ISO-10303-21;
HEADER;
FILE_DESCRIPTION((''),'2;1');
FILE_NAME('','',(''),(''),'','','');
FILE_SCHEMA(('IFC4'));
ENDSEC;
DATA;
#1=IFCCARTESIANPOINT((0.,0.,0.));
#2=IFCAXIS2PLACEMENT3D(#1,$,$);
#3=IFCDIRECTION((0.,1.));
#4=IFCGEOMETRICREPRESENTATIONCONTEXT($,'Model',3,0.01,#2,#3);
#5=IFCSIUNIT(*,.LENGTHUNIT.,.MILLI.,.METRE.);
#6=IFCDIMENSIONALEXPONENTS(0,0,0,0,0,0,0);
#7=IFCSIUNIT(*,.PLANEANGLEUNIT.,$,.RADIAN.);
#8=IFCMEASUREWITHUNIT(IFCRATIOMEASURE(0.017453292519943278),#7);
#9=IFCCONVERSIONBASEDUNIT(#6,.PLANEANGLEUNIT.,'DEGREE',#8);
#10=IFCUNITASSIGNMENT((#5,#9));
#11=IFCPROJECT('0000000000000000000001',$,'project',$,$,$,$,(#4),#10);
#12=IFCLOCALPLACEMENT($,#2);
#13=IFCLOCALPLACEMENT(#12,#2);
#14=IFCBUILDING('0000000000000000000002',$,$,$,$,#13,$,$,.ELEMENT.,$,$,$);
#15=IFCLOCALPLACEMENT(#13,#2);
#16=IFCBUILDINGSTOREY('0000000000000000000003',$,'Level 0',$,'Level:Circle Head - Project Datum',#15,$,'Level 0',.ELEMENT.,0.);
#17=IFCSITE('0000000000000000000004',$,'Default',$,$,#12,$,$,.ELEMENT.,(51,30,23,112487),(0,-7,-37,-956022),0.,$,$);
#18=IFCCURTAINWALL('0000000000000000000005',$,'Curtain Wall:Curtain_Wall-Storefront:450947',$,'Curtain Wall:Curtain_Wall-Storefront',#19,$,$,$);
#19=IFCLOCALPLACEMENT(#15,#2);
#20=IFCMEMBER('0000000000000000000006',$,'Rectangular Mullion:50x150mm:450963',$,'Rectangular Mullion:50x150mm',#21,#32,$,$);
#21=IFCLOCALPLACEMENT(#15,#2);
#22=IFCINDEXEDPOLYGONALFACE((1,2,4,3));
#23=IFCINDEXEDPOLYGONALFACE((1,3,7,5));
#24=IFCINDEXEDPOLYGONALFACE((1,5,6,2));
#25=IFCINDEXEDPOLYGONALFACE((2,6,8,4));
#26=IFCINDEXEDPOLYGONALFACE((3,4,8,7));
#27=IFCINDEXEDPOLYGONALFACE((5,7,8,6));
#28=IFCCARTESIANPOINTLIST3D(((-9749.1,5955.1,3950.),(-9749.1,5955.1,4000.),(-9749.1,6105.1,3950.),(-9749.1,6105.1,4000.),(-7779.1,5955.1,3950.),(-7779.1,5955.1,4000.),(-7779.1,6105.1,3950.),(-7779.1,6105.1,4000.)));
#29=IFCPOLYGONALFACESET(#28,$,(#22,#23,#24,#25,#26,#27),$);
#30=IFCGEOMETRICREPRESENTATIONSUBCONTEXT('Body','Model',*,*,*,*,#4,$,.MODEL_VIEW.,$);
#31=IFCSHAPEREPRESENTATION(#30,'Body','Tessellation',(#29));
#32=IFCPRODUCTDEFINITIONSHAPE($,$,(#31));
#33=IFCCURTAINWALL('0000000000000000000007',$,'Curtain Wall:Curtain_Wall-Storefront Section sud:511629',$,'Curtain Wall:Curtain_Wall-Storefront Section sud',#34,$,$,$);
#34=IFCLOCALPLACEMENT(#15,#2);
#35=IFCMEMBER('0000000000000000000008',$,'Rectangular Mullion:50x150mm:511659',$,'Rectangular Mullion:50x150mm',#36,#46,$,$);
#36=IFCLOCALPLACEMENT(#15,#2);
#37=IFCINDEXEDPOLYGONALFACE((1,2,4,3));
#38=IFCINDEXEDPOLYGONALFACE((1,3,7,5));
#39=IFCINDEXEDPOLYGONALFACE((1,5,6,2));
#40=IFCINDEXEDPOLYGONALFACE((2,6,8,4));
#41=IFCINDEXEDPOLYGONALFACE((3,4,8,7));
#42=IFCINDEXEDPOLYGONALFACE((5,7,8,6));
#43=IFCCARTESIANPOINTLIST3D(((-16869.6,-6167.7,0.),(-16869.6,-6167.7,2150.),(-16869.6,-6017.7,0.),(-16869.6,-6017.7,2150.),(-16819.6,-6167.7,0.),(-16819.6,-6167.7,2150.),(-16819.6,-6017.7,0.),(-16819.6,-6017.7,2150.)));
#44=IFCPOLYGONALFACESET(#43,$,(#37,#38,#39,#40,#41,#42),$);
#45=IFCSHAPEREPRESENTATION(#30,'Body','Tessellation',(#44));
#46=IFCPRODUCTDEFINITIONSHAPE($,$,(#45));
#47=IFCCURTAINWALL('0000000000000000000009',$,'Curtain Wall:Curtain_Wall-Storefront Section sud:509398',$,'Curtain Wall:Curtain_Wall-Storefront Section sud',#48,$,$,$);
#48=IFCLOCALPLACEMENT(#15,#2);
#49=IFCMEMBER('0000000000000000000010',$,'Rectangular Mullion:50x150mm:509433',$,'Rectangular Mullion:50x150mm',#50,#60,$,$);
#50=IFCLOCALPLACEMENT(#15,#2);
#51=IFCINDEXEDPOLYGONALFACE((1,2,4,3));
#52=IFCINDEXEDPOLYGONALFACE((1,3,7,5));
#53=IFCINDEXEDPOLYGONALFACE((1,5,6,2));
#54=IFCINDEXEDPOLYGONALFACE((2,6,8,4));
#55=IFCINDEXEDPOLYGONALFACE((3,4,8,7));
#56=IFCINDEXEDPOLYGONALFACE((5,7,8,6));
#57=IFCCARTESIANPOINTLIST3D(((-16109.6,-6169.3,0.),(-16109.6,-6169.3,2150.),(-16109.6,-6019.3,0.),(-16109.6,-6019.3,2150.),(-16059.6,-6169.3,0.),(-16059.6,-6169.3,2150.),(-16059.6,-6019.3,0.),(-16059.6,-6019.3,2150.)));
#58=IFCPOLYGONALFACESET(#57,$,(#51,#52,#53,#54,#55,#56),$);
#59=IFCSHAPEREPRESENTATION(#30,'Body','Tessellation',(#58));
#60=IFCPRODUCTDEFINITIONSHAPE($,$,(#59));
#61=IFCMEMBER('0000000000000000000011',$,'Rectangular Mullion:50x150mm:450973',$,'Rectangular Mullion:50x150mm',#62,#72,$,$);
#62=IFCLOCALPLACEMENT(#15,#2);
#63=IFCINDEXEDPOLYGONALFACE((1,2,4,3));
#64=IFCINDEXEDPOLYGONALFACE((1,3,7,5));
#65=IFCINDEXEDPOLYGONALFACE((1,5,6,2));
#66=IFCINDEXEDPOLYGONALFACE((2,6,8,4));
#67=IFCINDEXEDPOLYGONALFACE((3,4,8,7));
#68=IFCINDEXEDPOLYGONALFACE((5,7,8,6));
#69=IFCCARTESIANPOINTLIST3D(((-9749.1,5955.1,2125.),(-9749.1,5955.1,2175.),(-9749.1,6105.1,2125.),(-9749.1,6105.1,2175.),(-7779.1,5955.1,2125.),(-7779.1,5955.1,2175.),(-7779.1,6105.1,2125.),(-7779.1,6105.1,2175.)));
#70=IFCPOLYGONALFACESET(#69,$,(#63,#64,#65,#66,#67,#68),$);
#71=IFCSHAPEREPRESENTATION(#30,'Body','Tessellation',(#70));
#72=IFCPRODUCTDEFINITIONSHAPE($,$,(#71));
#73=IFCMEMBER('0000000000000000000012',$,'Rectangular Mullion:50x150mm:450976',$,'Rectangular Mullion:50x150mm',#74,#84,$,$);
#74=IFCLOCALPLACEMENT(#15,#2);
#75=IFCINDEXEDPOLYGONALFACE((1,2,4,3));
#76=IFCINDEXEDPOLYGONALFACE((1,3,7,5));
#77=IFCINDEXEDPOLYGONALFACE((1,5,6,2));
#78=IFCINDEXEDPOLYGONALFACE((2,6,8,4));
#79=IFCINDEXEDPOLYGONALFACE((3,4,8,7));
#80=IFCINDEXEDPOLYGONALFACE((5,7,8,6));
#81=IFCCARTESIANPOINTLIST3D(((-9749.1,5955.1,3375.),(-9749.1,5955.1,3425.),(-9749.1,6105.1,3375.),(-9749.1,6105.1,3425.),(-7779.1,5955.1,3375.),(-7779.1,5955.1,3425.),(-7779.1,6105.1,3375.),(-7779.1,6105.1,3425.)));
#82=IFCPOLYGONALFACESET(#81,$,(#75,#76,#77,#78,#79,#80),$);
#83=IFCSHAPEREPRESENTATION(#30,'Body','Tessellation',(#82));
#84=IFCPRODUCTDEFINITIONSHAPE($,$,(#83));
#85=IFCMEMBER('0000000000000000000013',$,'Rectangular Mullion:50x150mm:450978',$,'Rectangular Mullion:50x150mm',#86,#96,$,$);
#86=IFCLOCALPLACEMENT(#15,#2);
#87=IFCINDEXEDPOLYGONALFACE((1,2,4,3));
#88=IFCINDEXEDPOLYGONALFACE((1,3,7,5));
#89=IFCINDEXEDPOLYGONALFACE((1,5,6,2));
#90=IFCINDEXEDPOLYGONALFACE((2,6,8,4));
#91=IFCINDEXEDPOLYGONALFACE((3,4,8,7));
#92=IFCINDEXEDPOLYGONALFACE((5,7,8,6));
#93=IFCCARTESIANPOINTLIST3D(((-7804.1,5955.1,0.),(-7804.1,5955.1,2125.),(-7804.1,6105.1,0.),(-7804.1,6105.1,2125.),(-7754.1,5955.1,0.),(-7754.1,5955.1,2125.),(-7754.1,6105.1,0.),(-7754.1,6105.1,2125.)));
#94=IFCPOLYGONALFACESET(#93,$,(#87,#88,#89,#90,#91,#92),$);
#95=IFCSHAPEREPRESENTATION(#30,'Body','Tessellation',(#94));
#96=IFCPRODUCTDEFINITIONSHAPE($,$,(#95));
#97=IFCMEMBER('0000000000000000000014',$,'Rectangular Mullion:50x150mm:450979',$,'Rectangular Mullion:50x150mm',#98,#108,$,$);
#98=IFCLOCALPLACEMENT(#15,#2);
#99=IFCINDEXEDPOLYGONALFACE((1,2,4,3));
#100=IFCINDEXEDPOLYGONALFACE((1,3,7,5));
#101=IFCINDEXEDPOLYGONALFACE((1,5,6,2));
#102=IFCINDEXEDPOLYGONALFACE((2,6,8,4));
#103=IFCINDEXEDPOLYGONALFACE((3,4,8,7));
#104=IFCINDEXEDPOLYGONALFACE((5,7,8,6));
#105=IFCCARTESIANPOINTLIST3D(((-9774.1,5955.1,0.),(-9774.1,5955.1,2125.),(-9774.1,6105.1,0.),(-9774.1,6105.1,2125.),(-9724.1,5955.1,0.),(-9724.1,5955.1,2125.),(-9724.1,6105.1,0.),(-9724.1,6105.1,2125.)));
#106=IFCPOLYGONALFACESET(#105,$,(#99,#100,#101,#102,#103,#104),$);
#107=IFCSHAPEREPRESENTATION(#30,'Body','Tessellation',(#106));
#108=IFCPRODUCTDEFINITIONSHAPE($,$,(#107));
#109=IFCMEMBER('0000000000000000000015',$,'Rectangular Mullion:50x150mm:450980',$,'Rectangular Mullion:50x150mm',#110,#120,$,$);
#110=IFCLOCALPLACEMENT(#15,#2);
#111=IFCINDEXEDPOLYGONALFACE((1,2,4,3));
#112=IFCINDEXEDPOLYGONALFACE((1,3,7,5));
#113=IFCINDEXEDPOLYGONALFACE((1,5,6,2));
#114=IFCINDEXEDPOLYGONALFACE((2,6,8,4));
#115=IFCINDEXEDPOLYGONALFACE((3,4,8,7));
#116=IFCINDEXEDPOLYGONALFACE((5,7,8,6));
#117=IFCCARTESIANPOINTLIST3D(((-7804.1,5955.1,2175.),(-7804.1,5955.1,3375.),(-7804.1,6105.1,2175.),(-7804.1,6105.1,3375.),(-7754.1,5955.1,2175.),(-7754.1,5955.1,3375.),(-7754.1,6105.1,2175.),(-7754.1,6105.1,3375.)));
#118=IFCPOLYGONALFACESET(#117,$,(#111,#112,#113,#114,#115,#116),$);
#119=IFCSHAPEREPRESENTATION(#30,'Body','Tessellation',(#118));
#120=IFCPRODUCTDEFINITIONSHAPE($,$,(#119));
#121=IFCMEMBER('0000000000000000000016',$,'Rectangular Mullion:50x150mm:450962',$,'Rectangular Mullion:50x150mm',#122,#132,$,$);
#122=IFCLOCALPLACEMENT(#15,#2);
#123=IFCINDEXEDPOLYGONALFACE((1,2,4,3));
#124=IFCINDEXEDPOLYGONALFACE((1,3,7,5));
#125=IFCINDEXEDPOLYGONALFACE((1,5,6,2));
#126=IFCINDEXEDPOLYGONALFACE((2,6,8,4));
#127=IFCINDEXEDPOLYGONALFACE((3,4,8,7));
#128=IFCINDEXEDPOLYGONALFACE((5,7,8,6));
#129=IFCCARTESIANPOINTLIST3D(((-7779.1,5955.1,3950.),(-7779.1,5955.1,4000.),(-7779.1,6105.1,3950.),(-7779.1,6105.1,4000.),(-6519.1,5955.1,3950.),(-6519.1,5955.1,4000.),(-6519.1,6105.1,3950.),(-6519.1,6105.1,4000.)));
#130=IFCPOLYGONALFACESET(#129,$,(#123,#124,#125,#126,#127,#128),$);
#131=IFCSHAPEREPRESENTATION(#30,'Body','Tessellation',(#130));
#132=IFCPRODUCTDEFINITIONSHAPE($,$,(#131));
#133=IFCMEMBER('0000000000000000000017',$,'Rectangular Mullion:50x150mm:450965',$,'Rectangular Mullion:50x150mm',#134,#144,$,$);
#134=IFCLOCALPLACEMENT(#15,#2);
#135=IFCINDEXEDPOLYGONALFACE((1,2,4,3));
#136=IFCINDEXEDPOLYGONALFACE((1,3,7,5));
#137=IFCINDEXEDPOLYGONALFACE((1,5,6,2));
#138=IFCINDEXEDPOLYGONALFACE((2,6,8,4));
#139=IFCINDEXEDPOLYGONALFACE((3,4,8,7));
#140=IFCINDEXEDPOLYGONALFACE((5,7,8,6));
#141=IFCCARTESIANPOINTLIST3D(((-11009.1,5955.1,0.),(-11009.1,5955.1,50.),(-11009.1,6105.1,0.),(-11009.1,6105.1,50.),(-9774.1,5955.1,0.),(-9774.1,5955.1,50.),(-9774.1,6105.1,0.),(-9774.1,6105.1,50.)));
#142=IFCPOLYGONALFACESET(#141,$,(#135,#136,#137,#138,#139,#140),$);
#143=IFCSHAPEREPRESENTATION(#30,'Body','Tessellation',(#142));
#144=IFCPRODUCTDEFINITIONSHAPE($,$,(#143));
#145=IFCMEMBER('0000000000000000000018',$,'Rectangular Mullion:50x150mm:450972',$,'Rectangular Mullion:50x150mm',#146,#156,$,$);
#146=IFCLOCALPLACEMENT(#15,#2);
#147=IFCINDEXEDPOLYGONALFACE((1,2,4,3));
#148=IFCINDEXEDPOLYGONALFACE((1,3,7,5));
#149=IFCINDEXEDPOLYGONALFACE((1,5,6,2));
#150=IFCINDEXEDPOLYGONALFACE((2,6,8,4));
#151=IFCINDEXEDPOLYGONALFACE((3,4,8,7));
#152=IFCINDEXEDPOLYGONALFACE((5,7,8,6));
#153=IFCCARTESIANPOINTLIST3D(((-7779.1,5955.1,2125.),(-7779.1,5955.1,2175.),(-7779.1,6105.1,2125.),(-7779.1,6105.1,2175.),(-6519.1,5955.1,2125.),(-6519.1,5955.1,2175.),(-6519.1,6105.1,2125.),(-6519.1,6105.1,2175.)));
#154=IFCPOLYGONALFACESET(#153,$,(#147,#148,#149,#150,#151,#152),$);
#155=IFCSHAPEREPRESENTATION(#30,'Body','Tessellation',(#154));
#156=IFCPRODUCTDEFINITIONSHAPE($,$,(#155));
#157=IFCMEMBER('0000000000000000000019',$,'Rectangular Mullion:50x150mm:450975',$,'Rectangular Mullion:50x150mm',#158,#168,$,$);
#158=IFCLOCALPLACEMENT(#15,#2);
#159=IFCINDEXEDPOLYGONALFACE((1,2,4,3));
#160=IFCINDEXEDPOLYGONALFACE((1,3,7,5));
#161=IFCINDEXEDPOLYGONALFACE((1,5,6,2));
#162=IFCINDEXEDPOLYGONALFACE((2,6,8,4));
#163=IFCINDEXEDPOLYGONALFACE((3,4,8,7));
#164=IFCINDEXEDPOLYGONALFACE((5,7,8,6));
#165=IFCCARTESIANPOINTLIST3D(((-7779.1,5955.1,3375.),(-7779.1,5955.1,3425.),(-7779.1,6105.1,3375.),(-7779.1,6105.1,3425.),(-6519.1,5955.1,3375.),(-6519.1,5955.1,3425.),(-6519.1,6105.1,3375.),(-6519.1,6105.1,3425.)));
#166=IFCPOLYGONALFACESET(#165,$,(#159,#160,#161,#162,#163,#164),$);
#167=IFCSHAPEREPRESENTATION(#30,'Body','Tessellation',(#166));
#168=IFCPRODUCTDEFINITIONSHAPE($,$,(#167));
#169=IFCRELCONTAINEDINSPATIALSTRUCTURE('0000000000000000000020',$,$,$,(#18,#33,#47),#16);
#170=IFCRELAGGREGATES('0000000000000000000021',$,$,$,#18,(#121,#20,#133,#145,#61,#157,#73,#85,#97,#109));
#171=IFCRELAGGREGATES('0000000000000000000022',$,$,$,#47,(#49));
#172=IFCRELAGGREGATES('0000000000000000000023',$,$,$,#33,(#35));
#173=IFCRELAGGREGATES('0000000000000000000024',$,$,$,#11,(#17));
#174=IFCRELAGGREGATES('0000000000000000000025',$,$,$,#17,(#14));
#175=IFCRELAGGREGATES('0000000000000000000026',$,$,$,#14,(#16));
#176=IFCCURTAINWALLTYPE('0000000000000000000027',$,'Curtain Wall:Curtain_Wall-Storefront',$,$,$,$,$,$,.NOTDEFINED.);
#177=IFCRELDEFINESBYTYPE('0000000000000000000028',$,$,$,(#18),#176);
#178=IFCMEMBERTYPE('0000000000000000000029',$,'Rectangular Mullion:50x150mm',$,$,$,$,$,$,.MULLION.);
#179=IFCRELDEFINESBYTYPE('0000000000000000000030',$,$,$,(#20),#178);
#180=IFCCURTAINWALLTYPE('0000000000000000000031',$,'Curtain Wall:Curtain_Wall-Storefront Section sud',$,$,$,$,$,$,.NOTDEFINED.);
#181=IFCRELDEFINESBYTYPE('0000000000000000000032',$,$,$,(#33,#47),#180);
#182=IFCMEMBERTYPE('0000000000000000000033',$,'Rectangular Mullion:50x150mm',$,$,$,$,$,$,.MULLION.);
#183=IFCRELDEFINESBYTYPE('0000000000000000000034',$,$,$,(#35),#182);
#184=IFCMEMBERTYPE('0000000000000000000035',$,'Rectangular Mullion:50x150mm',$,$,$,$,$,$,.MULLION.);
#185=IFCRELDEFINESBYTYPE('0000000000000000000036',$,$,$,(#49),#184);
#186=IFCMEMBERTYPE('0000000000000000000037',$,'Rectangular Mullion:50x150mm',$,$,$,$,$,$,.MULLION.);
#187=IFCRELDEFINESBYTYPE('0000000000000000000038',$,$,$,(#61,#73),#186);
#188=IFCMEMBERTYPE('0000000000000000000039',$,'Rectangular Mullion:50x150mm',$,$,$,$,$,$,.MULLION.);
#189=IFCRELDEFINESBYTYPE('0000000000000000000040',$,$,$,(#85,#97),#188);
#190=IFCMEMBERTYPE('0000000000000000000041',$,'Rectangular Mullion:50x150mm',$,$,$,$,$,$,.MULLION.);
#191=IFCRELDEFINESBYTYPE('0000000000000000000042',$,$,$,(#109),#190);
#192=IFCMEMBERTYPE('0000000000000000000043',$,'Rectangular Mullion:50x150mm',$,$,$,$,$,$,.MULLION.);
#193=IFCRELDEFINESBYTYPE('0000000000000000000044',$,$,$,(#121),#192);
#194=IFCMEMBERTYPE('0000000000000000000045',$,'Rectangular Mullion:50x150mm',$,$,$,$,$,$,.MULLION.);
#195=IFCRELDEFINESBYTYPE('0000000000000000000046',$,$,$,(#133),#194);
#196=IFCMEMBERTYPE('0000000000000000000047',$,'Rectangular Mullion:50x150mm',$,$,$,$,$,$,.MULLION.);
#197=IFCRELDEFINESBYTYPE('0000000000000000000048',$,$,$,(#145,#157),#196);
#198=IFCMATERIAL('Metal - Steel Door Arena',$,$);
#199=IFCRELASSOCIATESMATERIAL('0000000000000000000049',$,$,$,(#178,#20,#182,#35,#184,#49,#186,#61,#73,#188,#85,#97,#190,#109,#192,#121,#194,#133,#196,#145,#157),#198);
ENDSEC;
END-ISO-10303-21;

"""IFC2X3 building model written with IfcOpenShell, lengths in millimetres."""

from ifc_helpers import new_model, entity, si_unit, converted_unit, direction, frame, origin, origin_2d_with_axis, place, context, subcontext, project, spatial, rectangle, extrude, source, transform, mapped, material, type_object, type_shapes, element, aggregate, save


model = new_model("IFC2X3")

# Units and contexts
model_context = context("Model", 3, precision=0.01, world=origin(), true_north=direction((0.0, 1.0)))
body_context = subcontext(model_context, "Body", "Model", "MODEL_VIEW")
ifc_project = project(units=[si_unit("LENGTHUNIT", "METRE", prefix="MILLI"), converted_unit("PLANEANGLEUNIT", "DEGREE", entity("IfcRatioMeasure", 0.017453292519943278), si_unit("PLANEANGLEUNIT", "RADIAN"), dimensions=[0, 0, 0, 0, 0, 0, 0])], contexts=[model_context])

# Site, building, storey
site_placement = place(None, origin())
site = spatial("IfcSite", under=ifc_project, at=site_placement, Name="Default", CompositionType="ELEMENT", RefLatitude=(51, 30, 23, 112487), RefLongitude=(0, -7, -37, -956022), RefElevation=0.0)
building_placement = place(site_placement, origin())
building = spatial("IfcBuilding", under=site, at=building_placement, CompositionType="ELEMENT")
storey_placement = place(building_placement, origin())
storey = spatial("IfcBuildingStorey", under=building, at=storey_placement, Name="Level 0", ObjectType="Level:Circle Head - Project Datum", LongName="Level 0", CompositionType="ELEMENT", Elevation=0.0)

# Curtain walls, members
curtain_wall_type_1 = type_object("IfcCurtainWallType", Name="Curtain Wall:Curtain_Wall-Storefront", PredefinedType="NOTDEFINED")
curtain_wall_1_placement = place(storey_placement, origin())
curtain_wall_1 = element("IfcCurtainWall", 1, at=curtain_wall_1_placement, inside=storey, type_object=curtain_wall_type_1, Name="Curtain Wall:Curtain_Wall-Storefront:450947", ObjectType="Curtain Wall:Curtain_Wall-Storefront")
ifc_material_1 = material(Name="Metal - Steel Door Arena")
member_type_1 = type_object("IfcMemberType", Name="Rectangular Mullion:50x150mm", PredefinedType="MULLION", material=ifc_material_1)
shared_shape_1 = source(origin(), body_context, "Body", "SweptSolid", [
    extrude(rectangle(XDim=150.0, YDim=50.0, at=origin_2d_with_axis()), frame((-25.0, 0.0, -1970.0), z_axis=(0.0, 0.0, 1.0), x_axis=(0.0, -1.0, 0.0)), (0.0, 0.0, 1.0), 1970.0),
])
type_shapes(member_type_1, [shared_shape_1])
member_1_placement = place(curtain_wall_1_placement, frame((-9749.1, 6030.1, 4000.0), z_axis=(-1.0, 0.0, 0.0), x_axis=(0.0, 0.0, 1.0)))
member_1 = element("IfcMember", 2, at=member_1_placement, type_object=member_type_1, material=ifc_material_1, Name="Rectangular Mullion:50x150mm:450963", ObjectType="Rectangular Mullion:50x150mm", context=body_context, shape_type="MappedRepresentation", body=[
    mapped(shared_shape_1, transform((0.0, 0.0, 0.0), scale=1.0)),
])
curtain_wall_type_2 = type_object("IfcCurtainWallType", Name="Curtain Wall:Curtain_Wall-Storefront Section sud", PredefinedType="NOTDEFINED")
curtain_wall_2_placement = place(storey_placement, origin())
curtain_wall_2 = element("IfcCurtainWall", 3, at=curtain_wall_2_placement, inside=storey, type_object=curtain_wall_type_2, Name="Curtain Wall:Curtain_Wall-Storefront Section sud:511629", ObjectType="Curtain Wall:Curtain_Wall-Storefront Section sud")
member_type_2 = type_object("IfcMemberType", Name="Rectangular Mullion:50x150mm", PredefinedType="MULLION", material=ifc_material_1)
shared_shape_2 = source(origin(), body_context, "Body", "SweptSolid", [
    extrude(rectangle(XDim=150.0, YDim=50.0, at=origin_2d_with_axis()), frame((-25.0, 0.0, -2150.0), z_axis=(0.0, 0.0, 1.0), x_axis=(0.0, -1.0, 0.0)), (0.0, 0.0, 1.0), 2150.0),
])
type_shapes(member_type_2, [shared_shape_2])
member_2_placement = place(curtain_wall_2_placement, frame((-16819.6, -6092.7, 0.0), z_axis=(0.0, 0.0, -1.0), x_axis=(1.0, 0.0, 0.0)))
member_2 = element("IfcMember", 4, at=member_2_placement, type_object=member_type_2, material=ifc_material_1, Name="Rectangular Mullion:50x150mm:511659", ObjectType="Rectangular Mullion:50x150mm", context=body_context, shape_type="MappedRepresentation", body=[
    mapped(shared_shape_2, transform((0.0, 0.0, 0.0), scale=1.0)),
])
curtain_wall_3_placement = place(storey_placement, origin())
curtain_wall_3 = element("IfcCurtainWall", 5, at=curtain_wall_3_placement, inside=storey, type_object=curtain_wall_type_2, Name="Curtain Wall:Curtain_Wall-Storefront Section sud:509398", ObjectType="Curtain Wall:Curtain_Wall-Storefront Section sud")
member_type_3 = type_object("IfcMemberType", Name="Rectangular Mullion:50x150mm", PredefinedType="MULLION", material=ifc_material_1)
shared_shape_3 = source(origin(), body_context, "Body", "SweptSolid", [
    extrude(rectangle(XDim=150.0, YDim=50.0, at=origin_2d_with_axis()), frame((-25.0, 0.0, -2150.0), z_axis=(0.0, 0.0, 1.0), x_axis=(0.0, -1.0, 0.0)), (0.0, 0.0, 1.0), 2150.0),
])
type_shapes(member_type_3, [shared_shape_3])
member_3_placement = place(curtain_wall_3_placement, frame((-16109.6, -6094.3, 2150.0), z_axis=(0.0, 0.0, 1.0), x_axis=(-1.0, 0.0, 0.0)))
member_3 = element("IfcMember", 6, at=member_3_placement, type_object=member_type_3, material=ifc_material_1, Name="Rectangular Mullion:50x150mm:509433", ObjectType="Rectangular Mullion:50x150mm", context=body_context, shape_type="MappedRepresentation", body=[
    mapped(shared_shape_3, transform((0.0, 0.0, 0.0), scale=1.0)),
])

# Members
member_type_4 = type_object("IfcMemberType", Name="Rectangular Mullion:50x150mm", PredefinedType="MULLION", material=ifc_material_1)
shared_shape_4 = source(origin(), body_context, "Body", "SweptSolid", [
    extrude(rectangle(XDim=150.0, YDim=50.0, at=origin_2d_with_axis()), frame((0.0, 0.0, -1970.0), z_axis=(0.0, 0.0, 1.0), x_axis=(0.0, -1.0, 0.0)), (0.0, 0.0, 1.0), 1970.0),
])
type_shapes(member_type_4, [shared_shape_4])
member_4_placement = place(curtain_wall_1_placement, frame((-9749.1, 6030.1, 2150.0), z_axis=(-1.0, 0.0, 0.0), x_axis=(0.0, 0.0, 1.0)))
member_4 = element("IfcMember", 7, at=member_4_placement, type_object=member_type_4, material=ifc_material_1, Name="Rectangular Mullion:50x150mm:450973", ObjectType="Rectangular Mullion:50x150mm", context=body_context, shape_type="MappedRepresentation", body=[
    mapped(shared_shape_4, transform((0.0, 0.0, 0.0), scale=1.0)),
])
member_5_placement = place(curtain_wall_1_placement, frame((-9749.1, 6030.1, 3400.0), z_axis=(-1.0, 0.0, 0.0), x_axis=(0.0, 0.0, 1.0)))
member_5 = element("IfcMember", 8, at=member_5_placement, type_object=member_type_4, material=ifc_material_1, Name="Rectangular Mullion:50x150mm:450976", ObjectType="Rectangular Mullion:50x150mm", context=body_context, shape_type="MappedRepresentation", body=[
    mapped(shared_shape_4, transform((0.0, 0.0, 0.0), scale=1.0)),
])
member_type_5 = type_object("IfcMemberType", Name="Rectangular Mullion:50x150mm", PredefinedType="MULLION", material=ifc_material_1)
shared_shape_5 = source(origin(), body_context, "Body", "SweptSolid", [
    extrude(rectangle(XDim=150.0, YDim=50.0, at=origin_2d_with_axis()), frame((0.0, 0.0, -2125.0), z_axis=(0.0, 0.0, 1.0), x_axis=(0.0, -1.0, 0.0)), (0.0, 0.0, 1.0), 2125.0),
])
type_shapes(member_type_5, [shared_shape_5])
member_6_placement = place(curtain_wall_1_placement, frame((-7779.1, 6030.1, 0.0), z_axis=(0.0, 0.0, -1.0), x_axis=(-1.0, 0.0, 0.0)))
member_6 = element("IfcMember", 9, at=member_6_placement, type_object=member_type_5, material=ifc_material_1, Name="Rectangular Mullion:50x150mm:450978", ObjectType="Rectangular Mullion:50x150mm", context=body_context, shape_type="MappedRepresentation", body=[
    mapped(shared_shape_5, transform((0.0, 0.0, 0.0), scale=1.0)),
])
member_7_placement = place(curtain_wall_1_placement, frame((-9749.1, 6030.1, 0.0), z_axis=(0.0, 0.0, -1.0), x_axis=(-1.0, 0.0, 0.0)))
member_7 = element("IfcMember", 10, at=member_7_placement, type_object=member_type_5, material=ifc_material_1, Name="Rectangular Mullion:50x150mm:450979", ObjectType="Rectangular Mullion:50x150mm", context=body_context, shape_type="MappedRepresentation", body=[
    mapped(shared_shape_5, transform((0.0, 0.0, 0.0), scale=1.0)),
])
member_type_6 = type_object("IfcMemberType", Name="Rectangular Mullion:50x150mm", PredefinedType="MULLION", material=ifc_material_1)
shared_shape_6 = source(origin(), body_context, "Body", "SweptSolid", [
    extrude(rectangle(XDim=150.0, YDim=50.0, at=origin_2d_with_axis()), frame((0.0, 0.0, -1200.0), z_axis=(0.0, 0.0, 1.0), x_axis=(0.0, -1.0, 0.0)), (0.0, 0.0, 1.0), 1200.0),
])
type_shapes(member_type_6, [shared_shape_6])
member_8_placement = place(curtain_wall_1_placement, frame((-7779.1, 6030.1, 2175.0), z_axis=(0.0, 0.0, -1.0), x_axis=(-1.0, 0.0, 0.0)))
member_8 = element("IfcMember", 11, at=member_8_placement, type_object=member_type_6, material=ifc_material_1, Name="Rectangular Mullion:50x150mm:450980", ObjectType="Rectangular Mullion:50x150mm", context=body_context, shape_type="MappedRepresentation", body=[
    mapped(shared_shape_6, transform((0.0, 0.0, 0.0), scale=1.0)),
])
member_type_7 = type_object("IfcMemberType", Name="Rectangular Mullion:50x150mm", PredefinedType="MULLION", material=ifc_material_1)
shared_shape_7 = source(origin(), body_context, "Body", "SweptSolid", [
    extrude(rectangle(XDim=150.0, YDim=50.0, at=origin_2d_with_axis()), frame((-25.0, 0.0, -1260.0), z_axis=(0.0, 0.0, 1.0), x_axis=(0.0, -1.0, 0.0)), (0.0, 0.0, 1.0), 1260.0),
])
type_shapes(member_type_7, [shared_shape_7])
member_9_placement = place(curtain_wall_1_placement, frame((-7779.1, 6030.1, 4000.0), z_axis=(-1.0, 0.0, 0.0), x_axis=(0.0, 0.0, 1.0)))
member_9 = element("IfcMember", 12, at=member_9_placement, type_object=member_type_7, material=ifc_material_1, Name="Rectangular Mullion:50x150mm:450962", ObjectType="Rectangular Mullion:50x150mm", context=body_context, shape_type="MappedRepresentation", body=[
    mapped(shared_shape_7, transform((0.0, 0.0, 0.0), scale=1.0)),
])
member_type_8 = type_object("IfcMemberType", Name="Rectangular Mullion:50x150mm", PredefinedType="MULLION", material=ifc_material_1)
shared_shape_8 = source(origin(), body_context, "Body", "SweptSolid", [
    extrude(rectangle(XDim=150.0, YDim=50.0, at=origin_2d_with_axis()), frame((-25.0, 0.0, -1235.0), z_axis=(0.0, 0.0, 1.0), x_axis=(0.0, -1.0, 0.0)), (0.0, 0.0, 1.0), 1235.0),
])
type_shapes(member_type_8, [shared_shape_8])
member_10_placement = place(curtain_wall_1_placement, frame((-9774.1, 6030.1, 0.0), z_axis=(1.0, 0.0, 0.0), x_axis=(0.0, 0.0, -1.0)))
member_10 = element("IfcMember", 13, at=member_10_placement, type_object=member_type_8, material=ifc_material_1, Name="Rectangular Mullion:50x150mm:450965", ObjectType="Rectangular Mullion:50x150mm", context=body_context, shape_type="MappedRepresentation", body=[
    mapped(shared_shape_8, transform((0.0, 0.0, 0.0), scale=1.0)),
])
member_type_9 = type_object("IfcMemberType", Name="Rectangular Mullion:50x150mm", PredefinedType="MULLION", material=ifc_material_1)
shared_shape_9 = source(origin(), body_context, "Body", "SweptSolid", [
    extrude(rectangle(XDim=150.0, YDim=50.0, at=origin_2d_with_axis()), frame((0.0, 0.0, -1260.0), z_axis=(0.0, 0.0, 1.0), x_axis=(0.0, -1.0, 0.0)), (0.0, 0.0, 1.0), 1260.0),
])
type_shapes(member_type_9, [shared_shape_9])
member_11_placement = place(curtain_wall_1_placement, frame((-7779.1, 6030.1, 2150.0), z_axis=(-1.0, 0.0, 0.0), x_axis=(0.0, 0.0, 1.0)))
member_11 = element("IfcMember", 14, at=member_11_placement, type_object=member_type_9, material=ifc_material_1, Name="Rectangular Mullion:50x150mm:450972", ObjectType="Rectangular Mullion:50x150mm", context=body_context, shape_type="MappedRepresentation", body=[
    mapped(shared_shape_9, transform((0.0, 0.0, 0.0), scale=1.0)),
])
member_12_placement = place(curtain_wall_1_placement, frame((-7779.1, 6030.1, 3400.0), z_axis=(-1.0, 0.0, 0.0), x_axis=(0.0, 0.0, 1.0)))
member_12 = element("IfcMember", 15, at=member_12_placement, type_object=member_type_9, material=ifc_material_1, Name="Rectangular Mullion:50x150mm:450975", ObjectType="Rectangular Mullion:50x150mm", context=body_context, shape_type="MappedRepresentation", body=[
    mapped(shared_shape_9, transform((0.0, 0.0, 0.0), scale=1.0)),
])

aggregate(curtain_wall_1, [member_9, member_1, member_10, member_11, member_4, member_12, member_5, member_6, member_7, member_8])
aggregate(curtain_wall_3, [member_3])
aggregate(curtain_wall_2, [member_2])

save(model, "model.ifc")
